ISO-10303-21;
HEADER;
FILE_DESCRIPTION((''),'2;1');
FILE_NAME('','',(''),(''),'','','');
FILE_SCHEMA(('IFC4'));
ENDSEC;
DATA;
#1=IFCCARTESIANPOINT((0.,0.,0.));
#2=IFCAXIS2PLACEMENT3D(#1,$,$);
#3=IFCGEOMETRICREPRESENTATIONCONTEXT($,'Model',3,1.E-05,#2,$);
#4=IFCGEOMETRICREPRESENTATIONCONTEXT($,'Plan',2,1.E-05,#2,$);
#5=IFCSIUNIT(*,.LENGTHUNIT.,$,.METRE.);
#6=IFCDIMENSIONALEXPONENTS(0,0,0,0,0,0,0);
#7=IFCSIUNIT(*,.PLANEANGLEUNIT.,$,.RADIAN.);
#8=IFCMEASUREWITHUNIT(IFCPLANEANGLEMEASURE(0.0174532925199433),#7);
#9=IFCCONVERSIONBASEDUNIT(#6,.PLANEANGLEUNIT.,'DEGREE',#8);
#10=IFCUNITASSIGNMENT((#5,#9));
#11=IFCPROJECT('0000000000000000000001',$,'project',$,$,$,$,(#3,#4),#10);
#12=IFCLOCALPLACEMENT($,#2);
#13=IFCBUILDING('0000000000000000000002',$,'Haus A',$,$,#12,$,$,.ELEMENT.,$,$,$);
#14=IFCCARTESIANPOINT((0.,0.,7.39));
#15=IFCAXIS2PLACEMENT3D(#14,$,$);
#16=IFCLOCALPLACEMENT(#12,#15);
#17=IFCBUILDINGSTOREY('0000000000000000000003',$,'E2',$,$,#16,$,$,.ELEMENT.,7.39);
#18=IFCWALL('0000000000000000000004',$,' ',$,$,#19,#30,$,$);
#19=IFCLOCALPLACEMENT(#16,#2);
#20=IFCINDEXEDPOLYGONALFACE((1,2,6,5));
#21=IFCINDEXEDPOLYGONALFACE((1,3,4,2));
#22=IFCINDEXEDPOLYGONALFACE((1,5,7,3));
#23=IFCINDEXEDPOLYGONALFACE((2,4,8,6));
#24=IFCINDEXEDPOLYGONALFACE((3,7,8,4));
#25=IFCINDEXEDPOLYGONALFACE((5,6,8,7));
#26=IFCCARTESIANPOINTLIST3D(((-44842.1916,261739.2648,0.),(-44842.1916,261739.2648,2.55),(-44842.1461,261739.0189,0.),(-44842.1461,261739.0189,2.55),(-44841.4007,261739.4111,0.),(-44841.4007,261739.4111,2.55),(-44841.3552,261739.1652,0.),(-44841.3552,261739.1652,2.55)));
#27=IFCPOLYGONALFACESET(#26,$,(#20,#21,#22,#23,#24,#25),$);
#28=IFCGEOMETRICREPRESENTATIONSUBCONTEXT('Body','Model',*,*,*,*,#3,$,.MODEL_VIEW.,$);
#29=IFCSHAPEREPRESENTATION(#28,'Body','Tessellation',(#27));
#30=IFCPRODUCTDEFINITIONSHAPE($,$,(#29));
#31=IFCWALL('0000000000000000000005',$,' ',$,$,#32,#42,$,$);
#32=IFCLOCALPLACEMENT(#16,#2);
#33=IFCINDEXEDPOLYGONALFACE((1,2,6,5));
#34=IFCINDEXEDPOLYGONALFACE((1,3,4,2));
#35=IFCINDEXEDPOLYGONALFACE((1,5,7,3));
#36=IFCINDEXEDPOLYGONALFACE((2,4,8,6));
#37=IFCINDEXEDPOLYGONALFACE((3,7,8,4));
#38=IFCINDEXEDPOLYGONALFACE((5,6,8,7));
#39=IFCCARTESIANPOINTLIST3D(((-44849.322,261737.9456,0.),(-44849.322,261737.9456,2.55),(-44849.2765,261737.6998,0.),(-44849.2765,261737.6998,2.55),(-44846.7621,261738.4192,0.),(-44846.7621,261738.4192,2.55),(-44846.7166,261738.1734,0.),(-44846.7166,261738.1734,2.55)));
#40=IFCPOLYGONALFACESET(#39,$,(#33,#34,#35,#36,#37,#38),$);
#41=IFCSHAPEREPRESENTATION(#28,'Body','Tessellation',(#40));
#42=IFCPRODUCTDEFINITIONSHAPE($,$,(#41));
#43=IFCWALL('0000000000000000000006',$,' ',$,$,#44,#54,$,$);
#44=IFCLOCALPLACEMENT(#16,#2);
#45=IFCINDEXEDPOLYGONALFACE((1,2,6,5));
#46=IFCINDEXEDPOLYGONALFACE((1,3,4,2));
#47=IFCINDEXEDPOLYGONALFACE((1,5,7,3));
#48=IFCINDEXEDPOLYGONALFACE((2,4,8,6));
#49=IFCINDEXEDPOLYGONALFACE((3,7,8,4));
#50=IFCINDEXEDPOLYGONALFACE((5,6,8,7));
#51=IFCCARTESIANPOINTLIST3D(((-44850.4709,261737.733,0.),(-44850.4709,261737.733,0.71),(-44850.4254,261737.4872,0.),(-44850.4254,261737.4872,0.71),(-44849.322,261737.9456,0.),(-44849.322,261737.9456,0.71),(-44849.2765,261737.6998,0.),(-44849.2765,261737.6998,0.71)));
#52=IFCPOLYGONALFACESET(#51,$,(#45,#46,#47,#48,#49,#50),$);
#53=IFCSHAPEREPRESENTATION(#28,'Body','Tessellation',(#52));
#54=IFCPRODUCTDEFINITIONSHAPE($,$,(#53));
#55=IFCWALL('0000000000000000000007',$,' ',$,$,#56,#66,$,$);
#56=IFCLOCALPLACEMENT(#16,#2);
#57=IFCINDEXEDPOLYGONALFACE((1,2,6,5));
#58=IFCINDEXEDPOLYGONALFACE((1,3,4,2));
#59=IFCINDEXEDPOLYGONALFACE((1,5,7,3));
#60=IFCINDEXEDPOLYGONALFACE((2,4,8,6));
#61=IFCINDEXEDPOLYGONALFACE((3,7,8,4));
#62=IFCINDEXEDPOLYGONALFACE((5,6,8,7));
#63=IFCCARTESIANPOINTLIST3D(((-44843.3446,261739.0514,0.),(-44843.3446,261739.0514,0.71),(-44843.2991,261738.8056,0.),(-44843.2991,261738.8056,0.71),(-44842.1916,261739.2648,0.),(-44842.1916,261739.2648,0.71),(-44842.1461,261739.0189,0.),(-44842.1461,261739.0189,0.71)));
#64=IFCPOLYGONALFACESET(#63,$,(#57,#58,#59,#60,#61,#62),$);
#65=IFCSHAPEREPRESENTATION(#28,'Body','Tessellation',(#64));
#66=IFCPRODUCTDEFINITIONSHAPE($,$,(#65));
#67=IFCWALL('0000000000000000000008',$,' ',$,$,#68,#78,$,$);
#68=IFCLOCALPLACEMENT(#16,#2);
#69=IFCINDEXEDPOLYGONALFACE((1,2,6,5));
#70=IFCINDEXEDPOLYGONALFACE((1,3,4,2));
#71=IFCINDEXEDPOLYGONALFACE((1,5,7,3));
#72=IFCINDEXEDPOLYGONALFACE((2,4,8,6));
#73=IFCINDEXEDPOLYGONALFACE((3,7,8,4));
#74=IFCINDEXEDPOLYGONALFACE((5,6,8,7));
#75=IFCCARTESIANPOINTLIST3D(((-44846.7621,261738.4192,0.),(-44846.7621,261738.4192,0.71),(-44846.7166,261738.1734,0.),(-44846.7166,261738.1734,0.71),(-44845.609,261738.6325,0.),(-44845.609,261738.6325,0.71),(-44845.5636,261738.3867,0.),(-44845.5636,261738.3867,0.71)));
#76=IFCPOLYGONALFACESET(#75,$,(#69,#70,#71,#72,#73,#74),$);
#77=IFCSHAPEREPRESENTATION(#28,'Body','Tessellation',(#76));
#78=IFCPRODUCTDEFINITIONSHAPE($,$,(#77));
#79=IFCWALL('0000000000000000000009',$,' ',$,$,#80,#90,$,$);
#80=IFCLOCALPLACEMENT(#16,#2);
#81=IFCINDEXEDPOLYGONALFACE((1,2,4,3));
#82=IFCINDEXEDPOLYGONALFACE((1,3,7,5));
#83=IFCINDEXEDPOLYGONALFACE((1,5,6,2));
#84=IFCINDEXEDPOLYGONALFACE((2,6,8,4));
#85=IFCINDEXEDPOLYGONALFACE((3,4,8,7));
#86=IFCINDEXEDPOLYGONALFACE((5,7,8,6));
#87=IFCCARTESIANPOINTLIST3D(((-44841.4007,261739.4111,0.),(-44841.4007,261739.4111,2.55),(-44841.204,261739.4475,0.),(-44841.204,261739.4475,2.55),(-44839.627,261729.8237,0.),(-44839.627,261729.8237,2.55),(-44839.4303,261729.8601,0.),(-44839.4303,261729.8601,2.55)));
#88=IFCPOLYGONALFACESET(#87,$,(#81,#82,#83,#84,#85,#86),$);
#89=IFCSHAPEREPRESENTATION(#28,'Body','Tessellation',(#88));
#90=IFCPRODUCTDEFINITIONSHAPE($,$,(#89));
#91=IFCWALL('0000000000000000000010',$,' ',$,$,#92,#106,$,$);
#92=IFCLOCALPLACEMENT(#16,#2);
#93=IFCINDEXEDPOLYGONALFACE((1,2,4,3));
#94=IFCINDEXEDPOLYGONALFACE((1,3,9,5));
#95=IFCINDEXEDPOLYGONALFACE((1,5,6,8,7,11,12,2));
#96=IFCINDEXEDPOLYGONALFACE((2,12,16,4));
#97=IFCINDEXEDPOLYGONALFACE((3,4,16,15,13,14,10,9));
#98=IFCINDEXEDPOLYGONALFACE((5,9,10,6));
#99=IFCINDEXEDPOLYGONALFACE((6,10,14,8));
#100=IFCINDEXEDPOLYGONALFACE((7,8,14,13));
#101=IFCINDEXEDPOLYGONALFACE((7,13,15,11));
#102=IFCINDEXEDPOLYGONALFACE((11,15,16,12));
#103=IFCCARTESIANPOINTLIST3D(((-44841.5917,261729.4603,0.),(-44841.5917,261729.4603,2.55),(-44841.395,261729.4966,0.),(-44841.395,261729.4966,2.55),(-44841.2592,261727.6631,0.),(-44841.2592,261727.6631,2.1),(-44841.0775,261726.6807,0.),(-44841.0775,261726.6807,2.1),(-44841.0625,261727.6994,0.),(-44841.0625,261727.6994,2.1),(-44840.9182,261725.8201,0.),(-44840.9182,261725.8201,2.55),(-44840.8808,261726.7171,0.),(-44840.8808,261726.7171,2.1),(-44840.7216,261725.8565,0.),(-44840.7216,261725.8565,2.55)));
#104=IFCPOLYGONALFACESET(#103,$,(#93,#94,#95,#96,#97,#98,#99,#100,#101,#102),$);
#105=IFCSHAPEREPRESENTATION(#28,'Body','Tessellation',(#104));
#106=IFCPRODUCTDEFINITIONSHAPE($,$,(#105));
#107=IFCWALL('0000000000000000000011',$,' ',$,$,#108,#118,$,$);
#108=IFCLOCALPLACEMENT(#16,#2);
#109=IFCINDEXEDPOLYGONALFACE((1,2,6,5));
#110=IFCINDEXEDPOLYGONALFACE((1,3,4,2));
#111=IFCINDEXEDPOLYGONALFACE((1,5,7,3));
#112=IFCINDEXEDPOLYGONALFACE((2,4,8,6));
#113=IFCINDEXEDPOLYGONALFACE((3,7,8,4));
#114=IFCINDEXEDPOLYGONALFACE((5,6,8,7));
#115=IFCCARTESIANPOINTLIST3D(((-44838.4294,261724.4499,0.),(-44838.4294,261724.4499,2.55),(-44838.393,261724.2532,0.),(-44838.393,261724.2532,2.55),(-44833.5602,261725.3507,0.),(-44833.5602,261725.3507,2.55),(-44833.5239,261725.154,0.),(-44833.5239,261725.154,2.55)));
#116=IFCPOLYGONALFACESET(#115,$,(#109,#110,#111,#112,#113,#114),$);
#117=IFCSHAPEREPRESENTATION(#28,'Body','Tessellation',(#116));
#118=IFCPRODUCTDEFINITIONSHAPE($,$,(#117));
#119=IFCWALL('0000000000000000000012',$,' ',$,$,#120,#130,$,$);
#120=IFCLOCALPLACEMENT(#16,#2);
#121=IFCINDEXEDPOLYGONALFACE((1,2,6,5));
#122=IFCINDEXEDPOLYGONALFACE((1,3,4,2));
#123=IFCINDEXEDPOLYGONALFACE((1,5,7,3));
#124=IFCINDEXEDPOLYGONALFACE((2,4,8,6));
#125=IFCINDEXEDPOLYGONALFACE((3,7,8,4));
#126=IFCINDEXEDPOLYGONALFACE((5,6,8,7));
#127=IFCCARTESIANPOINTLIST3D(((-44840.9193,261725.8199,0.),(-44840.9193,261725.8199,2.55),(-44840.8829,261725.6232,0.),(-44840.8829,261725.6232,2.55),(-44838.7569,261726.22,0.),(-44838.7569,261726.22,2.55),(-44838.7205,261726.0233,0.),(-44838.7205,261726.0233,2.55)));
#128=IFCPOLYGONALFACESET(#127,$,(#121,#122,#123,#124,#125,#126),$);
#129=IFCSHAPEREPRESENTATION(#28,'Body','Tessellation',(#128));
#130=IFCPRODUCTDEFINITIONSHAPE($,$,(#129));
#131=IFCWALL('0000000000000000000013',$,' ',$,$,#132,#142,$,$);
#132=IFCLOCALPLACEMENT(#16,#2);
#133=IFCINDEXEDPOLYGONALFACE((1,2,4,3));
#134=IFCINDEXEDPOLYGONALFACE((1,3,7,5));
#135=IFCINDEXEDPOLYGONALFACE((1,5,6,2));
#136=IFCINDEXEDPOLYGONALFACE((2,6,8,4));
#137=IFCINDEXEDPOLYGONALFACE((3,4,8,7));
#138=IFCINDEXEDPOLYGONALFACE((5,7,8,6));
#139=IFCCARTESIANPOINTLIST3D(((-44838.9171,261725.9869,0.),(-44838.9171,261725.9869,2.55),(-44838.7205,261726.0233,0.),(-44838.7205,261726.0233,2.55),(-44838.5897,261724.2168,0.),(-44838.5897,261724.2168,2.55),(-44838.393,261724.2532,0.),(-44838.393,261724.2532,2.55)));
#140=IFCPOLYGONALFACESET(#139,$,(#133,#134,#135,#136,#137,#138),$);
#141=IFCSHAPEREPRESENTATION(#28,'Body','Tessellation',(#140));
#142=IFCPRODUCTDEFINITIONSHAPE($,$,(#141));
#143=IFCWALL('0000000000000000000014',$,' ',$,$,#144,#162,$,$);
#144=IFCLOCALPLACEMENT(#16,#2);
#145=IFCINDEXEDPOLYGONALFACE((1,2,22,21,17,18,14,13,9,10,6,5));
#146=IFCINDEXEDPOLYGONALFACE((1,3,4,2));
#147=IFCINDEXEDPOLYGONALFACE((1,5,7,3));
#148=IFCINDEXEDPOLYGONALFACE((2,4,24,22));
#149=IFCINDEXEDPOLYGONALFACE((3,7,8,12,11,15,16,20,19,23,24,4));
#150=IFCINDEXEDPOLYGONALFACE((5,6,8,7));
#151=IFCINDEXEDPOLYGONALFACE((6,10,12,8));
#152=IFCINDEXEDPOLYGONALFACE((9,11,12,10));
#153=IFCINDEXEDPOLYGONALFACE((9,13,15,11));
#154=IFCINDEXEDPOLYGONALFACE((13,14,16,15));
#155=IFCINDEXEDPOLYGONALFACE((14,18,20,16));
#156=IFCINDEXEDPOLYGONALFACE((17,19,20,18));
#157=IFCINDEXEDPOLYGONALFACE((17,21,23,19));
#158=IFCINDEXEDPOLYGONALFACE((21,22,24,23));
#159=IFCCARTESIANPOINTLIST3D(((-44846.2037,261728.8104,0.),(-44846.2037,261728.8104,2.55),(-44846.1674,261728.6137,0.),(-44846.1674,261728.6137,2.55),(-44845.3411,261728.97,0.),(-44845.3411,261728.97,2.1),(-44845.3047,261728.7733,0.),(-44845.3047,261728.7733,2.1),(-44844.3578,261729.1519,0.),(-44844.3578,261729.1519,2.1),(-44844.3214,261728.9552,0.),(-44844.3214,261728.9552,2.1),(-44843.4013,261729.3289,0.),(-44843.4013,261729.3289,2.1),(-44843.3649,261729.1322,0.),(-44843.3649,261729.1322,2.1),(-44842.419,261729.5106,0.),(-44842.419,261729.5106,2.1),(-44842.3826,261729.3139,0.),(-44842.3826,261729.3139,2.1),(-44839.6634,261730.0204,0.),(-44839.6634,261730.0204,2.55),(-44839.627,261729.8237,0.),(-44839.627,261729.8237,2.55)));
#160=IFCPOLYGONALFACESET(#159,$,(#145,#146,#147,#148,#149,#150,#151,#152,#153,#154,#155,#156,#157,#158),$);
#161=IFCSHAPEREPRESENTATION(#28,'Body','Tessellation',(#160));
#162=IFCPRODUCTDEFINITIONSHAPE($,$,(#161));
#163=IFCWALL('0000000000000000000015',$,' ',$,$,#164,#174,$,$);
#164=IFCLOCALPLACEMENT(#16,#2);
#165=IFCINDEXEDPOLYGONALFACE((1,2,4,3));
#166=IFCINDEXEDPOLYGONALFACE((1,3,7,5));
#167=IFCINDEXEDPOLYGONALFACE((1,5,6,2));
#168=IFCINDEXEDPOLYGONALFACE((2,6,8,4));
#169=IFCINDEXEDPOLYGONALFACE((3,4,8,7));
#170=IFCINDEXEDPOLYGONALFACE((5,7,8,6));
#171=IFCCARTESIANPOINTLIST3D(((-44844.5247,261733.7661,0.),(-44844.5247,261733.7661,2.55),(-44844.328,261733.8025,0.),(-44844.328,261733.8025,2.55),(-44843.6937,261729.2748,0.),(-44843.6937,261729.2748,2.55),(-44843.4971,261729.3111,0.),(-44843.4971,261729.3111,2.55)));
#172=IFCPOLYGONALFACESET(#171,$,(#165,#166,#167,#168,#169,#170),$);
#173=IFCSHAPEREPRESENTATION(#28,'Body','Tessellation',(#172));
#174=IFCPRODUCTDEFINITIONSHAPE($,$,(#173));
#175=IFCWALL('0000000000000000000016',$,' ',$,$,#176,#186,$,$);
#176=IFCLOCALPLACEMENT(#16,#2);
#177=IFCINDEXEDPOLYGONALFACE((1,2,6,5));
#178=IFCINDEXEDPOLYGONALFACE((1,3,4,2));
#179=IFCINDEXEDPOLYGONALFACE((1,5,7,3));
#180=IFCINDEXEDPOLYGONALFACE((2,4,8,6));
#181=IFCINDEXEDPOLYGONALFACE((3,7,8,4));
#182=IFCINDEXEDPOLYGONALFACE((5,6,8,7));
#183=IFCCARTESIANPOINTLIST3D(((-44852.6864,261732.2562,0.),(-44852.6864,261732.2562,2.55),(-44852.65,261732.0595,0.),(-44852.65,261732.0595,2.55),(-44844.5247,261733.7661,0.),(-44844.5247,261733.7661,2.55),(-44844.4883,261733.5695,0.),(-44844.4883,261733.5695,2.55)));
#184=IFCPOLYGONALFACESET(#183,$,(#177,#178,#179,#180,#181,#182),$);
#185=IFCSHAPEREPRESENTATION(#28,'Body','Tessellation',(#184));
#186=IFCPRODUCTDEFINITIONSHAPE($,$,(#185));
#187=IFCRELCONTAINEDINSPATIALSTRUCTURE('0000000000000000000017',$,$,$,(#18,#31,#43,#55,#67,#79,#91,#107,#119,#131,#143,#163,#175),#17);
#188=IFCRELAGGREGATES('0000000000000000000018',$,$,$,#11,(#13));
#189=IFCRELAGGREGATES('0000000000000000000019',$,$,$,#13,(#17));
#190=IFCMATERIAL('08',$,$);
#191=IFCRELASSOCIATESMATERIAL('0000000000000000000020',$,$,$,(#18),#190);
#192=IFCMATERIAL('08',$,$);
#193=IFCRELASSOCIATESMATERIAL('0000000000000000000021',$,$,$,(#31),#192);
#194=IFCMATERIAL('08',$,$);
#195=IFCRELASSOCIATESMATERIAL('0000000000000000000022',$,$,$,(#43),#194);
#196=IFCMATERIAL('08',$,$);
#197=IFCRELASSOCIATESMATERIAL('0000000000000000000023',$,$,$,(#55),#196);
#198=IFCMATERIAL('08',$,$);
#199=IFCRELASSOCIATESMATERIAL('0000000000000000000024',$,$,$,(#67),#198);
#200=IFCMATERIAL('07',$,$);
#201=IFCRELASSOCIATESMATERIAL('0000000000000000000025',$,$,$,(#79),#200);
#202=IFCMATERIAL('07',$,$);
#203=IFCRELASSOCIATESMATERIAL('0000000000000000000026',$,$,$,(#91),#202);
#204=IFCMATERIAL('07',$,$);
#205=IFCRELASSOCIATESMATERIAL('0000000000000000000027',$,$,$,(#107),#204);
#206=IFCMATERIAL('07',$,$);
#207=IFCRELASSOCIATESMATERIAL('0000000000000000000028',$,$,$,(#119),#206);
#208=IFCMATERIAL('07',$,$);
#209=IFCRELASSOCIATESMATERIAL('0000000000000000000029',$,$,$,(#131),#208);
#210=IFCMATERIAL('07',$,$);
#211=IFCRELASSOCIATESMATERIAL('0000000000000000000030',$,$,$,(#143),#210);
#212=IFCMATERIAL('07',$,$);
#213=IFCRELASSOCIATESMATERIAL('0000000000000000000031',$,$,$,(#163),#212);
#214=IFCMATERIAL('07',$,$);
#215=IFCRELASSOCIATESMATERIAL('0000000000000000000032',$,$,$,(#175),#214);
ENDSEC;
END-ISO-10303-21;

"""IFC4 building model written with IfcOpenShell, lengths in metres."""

from ifc_helpers import new_model, entity, si_unit, converted_unit, frame, frame_2d, origin, origin_with_axes, place, context, subcontext, project, spatial, polyline, rectangle, outline, extrude, material, element, save


model = new_model("IFC4")

# Units and contexts
model_context = context("Model", 3, precision=1e-05, world=origin())
plan_context = context("Plan", 2, precision=1e-05, world=origin())
body_context = subcontext(model_context, "Body", "Model", "MODEL_VIEW")
ifc_project = project(units=[si_unit("LENGTHUNIT", "METRE"), converted_unit("PLANEANGLEUNIT", "DEGREE", entity("IfcPlaneAngleMeasure", 0.0174532925199433), si_unit("PLANEANGLEUNIT", "RADIAN"), dimensions=[0, 0, 0, 0, 0, 0, 0])], contexts=[model_context, plan_context])

# Building, storey
building_placement = place(None, origin())
building = spatial("IfcBuilding", under=ifc_project, at=building_placement, Name="Haus A", CompositionType="ELEMENT")
storey_placement = place(building_placement, frame((0.0, 0.0, 7.39)))
storey = spatial("IfcBuildingStorey", under=building, at=storey_placement, Name="E2", CompositionType="ELEMENT", Elevation=7.39)

# Walls
ifc_material_1 = material(Name="08")
wall_1_placement = place(storey_placement, frame((-44841.4007, 261739.4111, 0.0), z_axis=(0.0, 0.0, 1.0), x_axis=(-0.983313, -0.18192, 0.0)))
element("IfcWall", 1, at=wall_1_placement, inside=storey, material=ifc_material_1, Name=" ", context=body_context, shape_type="SweptSolid", body=[
    extrude(rectangle(XDim=0.8043, YDim=0.25, at=frame_2d((0.4022, 0.125), x_axis=(1.0, 0.0))), origin_with_axes(), (0.0, 0.0, 1.0), 2.55),
])
ifc_material_2 = material(Name="08")
wall_2_placement = place(storey_placement, frame((-44846.7621, 261738.4192, 0.0), z_axis=(0.0, 0.0, 1.0), x_axis=(-0.983313, -0.18192, 0.0)))
element("IfcWall", 2, at=wall_2_placement, inside=storey, material=ifc_material_2, Name=" ", context=body_context, shape_type="SweptSolid", body=[
    extrude(rectangle(XDim=2.6034, YDim=0.25, at=frame_2d((1.3017, 0.125), x_axis=(1.0, 0.0))), origin_with_axes(), (0.0, 0.0, 1.0), 2.55),
])
ifc_material_3 = material(Name="08")
wall_3_placement = place(storey_placement, frame((-44849.322, 261737.9456, 0.0), z_axis=(0.0, 0.0, 1.0), x_axis=(-0.983313, -0.18192, 0.0)))
element("IfcWall", 3, at=wall_3_placement, inside=storey, material=ifc_material_3, Name=" ", context=body_context, shape_type="SweptSolid", body=[
    extrude(rectangle(XDim=1.1684, YDim=0.25, at=frame_2d((0.5842, 0.125), x_axis=(1.0, 0.0))), origin_with_axes(), (0.0, 0.0, 1.0), 0.71),
])
ifc_material_4 = material(Name="08")
wall_4_placement = place(storey_placement, frame((-44842.1916, 261739.2648, 0.0), z_axis=(0.0, 0.0, 1.0), x_axis=(-0.983313, -0.18192, 0.0)))
element("IfcWall", 4, at=wall_4_placement, inside=storey, material=ifc_material_4, Name=" ", context=body_context, shape_type="SweptSolid", body=[
    extrude(rectangle(XDim=1.1726, YDim=0.25, at=frame_2d((0.5863, 0.125), x_axis=(1.0, 0.0))), origin_with_axes(), (0.0, 0.0, 1.0), 0.71),
])
ifc_material_5 = material(Name="08")
wall_5_placement = place(storey_placement, frame((-44845.609, 261738.6325, 0.0), z_axis=(0.0, 0.0, 1.0), x_axis=(-0.983313, -0.18192, 0.0)))
element("IfcWall", 5, at=wall_5_placement, inside=storey, material=ifc_material_5, Name=" ", context=body_context, shape_type="SweptSolid", body=[
    extrude(rectangle(XDim=1.1726, YDim=0.25, at=frame_2d((0.5863, 0.125), x_axis=(1.0, 0.0))), origin_with_axes(), (0.0, 0.0, 1.0), 0.71),
])
ifc_material_6 = material(Name="07")
wall_6_placement = place(storey_placement, frame((-44841.4007, 261739.4111, 0.0), z_axis=(0.0, 0.0, 1.0), x_axis=(0.18192, -0.983313, 0.0)))
element("IfcWall", 6, at=wall_6_placement, inside=storey, material=ifc_material_6, Name=" ", context=body_context, shape_type="SweptSolid", body=[
    extrude(rectangle(XDim=9.75, YDim=0.2, at=frame_2d((4.875, 0.1), x_axis=(1.0, 0.0))), origin_with_axes(), (0.0, 0.0, 1.0), 2.55),
])

# Wall, opening
ifc_material_7 = material(Name="07")
wall_7_placement = place(storey_placement, frame((-44841.5917, 261729.4603, 0.0), z_axis=(0.0, 0.0, 1.0), x_axis=(0.18192, -0.983313, 0.0)))
wall_7 = element("IfcWall", 7, at=wall_7_placement, inside=storey, material=ifc_material_7, Name=" ", context=body_context, shape_type="SweptSolid", body=[
    extrude(rectangle(XDim=3.7019, YDim=0.2, at=frame_2d((1.851, 0.1), x_axis=(1.0, 0.0))), origin_with_axes(), (0.0, 0.0, 1.0), 2.55),
])
opening_1_placement = place(wall_7_placement, frame((2.8267, 0.2, 0.0), z_axis=(0.0, -1.0, 0.0), x_axis=(0.0, 0.0, 1.0)))
element("IfcOpeningElement", 8, at=opening_1_placement, cuts=wall_7, ObjectType="Opening", context=body_context, shape_type="SweptSolid", body=[
    extrude(outline(polyline([(0.0, 0.999), (2.1, 0.999), (2.1, 0.0), (0.0, 0.0), (0.0, 0.999)])), origin_with_axes(), (0.0, 0.0, 1.0), 0.2),
])

# Walls
ifc_material_8 = material(Name="07")
wall_8_placement = place(storey_placement, frame((-44833.5602, 261725.3507, 0.0), z_axis=(0.0, 0.0, 1.0), x_axis=(-0.983313, -0.18192, 0.0)))
element("IfcWall", 9, at=wall_8_placement, inside=storey, material=ifc_material_8, Name=" ", context=body_context, shape_type="SweptSolid", body=[
    extrude(rectangle(XDim=4.9518, YDim=0.2, at=frame_2d((2.4759, 0.1), x_axis=(1.0, 0.0))), origin_with_axes(), (0.0, 0.0, 1.0), 2.55),
])
ifc_material_9 = material(Name="07")
wall_9_placement = place(storey_placement, frame((-44840.8829, 261725.6232, 0.0), z_axis=(0.0, 0.0, 1.0), x_axis=(0.983313, 0.18192, 0.0)))
element("IfcWall", 10, at=wall_9_placement, inside=storey, material=ifc_material_9, Name=" ", context=body_context, shape_type="SweptSolid", body=[
    extrude(rectangle(XDim=2.1991, YDim=0.2, at=frame_2d((1.0995, 0.1), x_axis=(1.0, 0.0))), origin_with_axes(), (0.0, 0.0, 1.0), 2.55),
])
ifc_material_10 = material(Name="07")
wall_10_placement = place(storey_placement, frame((-44838.9171, 261725.9869, 0.0), z_axis=(0.0, 0.0, 1.0), x_axis=(0.18192, -0.983313, 0.0)))
element("IfcWall", 11, at=wall_10_placement, inside=storey, material=ifc_material_10, Name=" ", context=body_context, shape_type="SweptSolid", body=[
    extrude(rectangle(XDim=1.8001, YDim=0.2, at=frame_2d((0.9001, 0.1), x_axis=(1.0, 0.0))), origin_with_axes(), (0.0, 0.0, 1.0), 2.55),
])

# Wall, openings
ifc_material_11 = material(Name="07")
wall_11_placement = place(storey_placement, frame((-44839.6634, 261730.0204, 0.0), z_axis=(0.0, 0.0, 1.0), x_axis=(-0.983313, -0.18192, 0.0)))
wall_11 = element("IfcWall", 12, at=wall_11_placement, inside=storey, material=ifc_material_11, Name=" ", context=body_context, shape_type="SweptSolid", body=[
    extrude(rectangle(XDim=6.6514, YDim=0.2, at=frame_2d((3.3257, 0.1), x_axis=(1.0, 0.0))), origin_with_axes(), (0.0, 0.0, 1.0), 2.55),
])
opening_2_placement = place(wall_11_placement, frame((2.8023, 0.0, 0.0), z_axis=(0.0, 1.0, 0.0), x_axis=(0.0, 0.0, 1.0)))
element("IfcOpeningElement", 13, at=opening_2_placement, cuts=wall_11, ObjectType="Opening", context=body_context, shape_type="SweptSolid", body=[
    extrude(outline(polyline([(0.0, 0.999), (2.1, 0.999), (2.1, 0.0), (0.0, 0.0), (0.0, 0.999)])), origin_with_axes(), (0.0, 0.0, 1.0), 0.2),
])
opening_3_placement = place(wall_11_placement, frame((4.774, 0.0, 0.0), z_axis=(0.0, 1.0, 0.0), x_axis=(0.0, 0.0, 1.0)))
element("IfcOpeningElement", 14, at=opening_3_placement, cuts=wall_11, ObjectType="Opening", context=body_context, shape_type="SweptSolid", body=[
    extrude(outline(polyline([(0.0, 0.0), (0.0, 1.0), (2.1, 1.0), (2.1, 0.0), (0.0, 0.0)])), origin_with_axes(), (0.0, 0.0, 1.0), 0.2),
])

# Walls
ifc_material_12 = material(Name="07")
wall_12_placement = place(storey_placement, frame((-44843.4971, 261729.3111, 0.0), z_axis=(0.0, 0.0, 1.0), x_axis=(-0.18192, 0.983313, 0.0)))
element("IfcWall", 15, at=wall_12_placement, inside=storey, material=ifc_material_12, Name=" ", context=body_context, shape_type="SweptSolid", body=[
    extrude(rectangle(XDim=4.5676, YDim=0.2, at=frame_2d((2.2838, 0.1), x_axis=(1.0, 0.0))), origin_with_axes(), (0.0, 0.0, 1.0), 2.55),
])
ifc_material_13 = material(Name="07")
wall_13_placement = place(storey_placement, frame((-44844.5247, 261733.7661, 0.0), z_axis=(0.0, 0.0, 1.0), x_axis=(-0.983313, -0.18192, 0.0)))
element("IfcWall", 16, at=wall_13_placement, inside=storey, material=ifc_material_13, Name=" ", context=body_context, shape_type="SweptSolid", body=[
    extrude(rectangle(XDim=8.3002, YDim=0.2, at=frame_2d((4.1501, 0.1), x_axis=(1.0, 0.0))), origin_with_axes(), (0.0, 0.0, 1.0), 2.55),
])

save(model, "model.ifc")
